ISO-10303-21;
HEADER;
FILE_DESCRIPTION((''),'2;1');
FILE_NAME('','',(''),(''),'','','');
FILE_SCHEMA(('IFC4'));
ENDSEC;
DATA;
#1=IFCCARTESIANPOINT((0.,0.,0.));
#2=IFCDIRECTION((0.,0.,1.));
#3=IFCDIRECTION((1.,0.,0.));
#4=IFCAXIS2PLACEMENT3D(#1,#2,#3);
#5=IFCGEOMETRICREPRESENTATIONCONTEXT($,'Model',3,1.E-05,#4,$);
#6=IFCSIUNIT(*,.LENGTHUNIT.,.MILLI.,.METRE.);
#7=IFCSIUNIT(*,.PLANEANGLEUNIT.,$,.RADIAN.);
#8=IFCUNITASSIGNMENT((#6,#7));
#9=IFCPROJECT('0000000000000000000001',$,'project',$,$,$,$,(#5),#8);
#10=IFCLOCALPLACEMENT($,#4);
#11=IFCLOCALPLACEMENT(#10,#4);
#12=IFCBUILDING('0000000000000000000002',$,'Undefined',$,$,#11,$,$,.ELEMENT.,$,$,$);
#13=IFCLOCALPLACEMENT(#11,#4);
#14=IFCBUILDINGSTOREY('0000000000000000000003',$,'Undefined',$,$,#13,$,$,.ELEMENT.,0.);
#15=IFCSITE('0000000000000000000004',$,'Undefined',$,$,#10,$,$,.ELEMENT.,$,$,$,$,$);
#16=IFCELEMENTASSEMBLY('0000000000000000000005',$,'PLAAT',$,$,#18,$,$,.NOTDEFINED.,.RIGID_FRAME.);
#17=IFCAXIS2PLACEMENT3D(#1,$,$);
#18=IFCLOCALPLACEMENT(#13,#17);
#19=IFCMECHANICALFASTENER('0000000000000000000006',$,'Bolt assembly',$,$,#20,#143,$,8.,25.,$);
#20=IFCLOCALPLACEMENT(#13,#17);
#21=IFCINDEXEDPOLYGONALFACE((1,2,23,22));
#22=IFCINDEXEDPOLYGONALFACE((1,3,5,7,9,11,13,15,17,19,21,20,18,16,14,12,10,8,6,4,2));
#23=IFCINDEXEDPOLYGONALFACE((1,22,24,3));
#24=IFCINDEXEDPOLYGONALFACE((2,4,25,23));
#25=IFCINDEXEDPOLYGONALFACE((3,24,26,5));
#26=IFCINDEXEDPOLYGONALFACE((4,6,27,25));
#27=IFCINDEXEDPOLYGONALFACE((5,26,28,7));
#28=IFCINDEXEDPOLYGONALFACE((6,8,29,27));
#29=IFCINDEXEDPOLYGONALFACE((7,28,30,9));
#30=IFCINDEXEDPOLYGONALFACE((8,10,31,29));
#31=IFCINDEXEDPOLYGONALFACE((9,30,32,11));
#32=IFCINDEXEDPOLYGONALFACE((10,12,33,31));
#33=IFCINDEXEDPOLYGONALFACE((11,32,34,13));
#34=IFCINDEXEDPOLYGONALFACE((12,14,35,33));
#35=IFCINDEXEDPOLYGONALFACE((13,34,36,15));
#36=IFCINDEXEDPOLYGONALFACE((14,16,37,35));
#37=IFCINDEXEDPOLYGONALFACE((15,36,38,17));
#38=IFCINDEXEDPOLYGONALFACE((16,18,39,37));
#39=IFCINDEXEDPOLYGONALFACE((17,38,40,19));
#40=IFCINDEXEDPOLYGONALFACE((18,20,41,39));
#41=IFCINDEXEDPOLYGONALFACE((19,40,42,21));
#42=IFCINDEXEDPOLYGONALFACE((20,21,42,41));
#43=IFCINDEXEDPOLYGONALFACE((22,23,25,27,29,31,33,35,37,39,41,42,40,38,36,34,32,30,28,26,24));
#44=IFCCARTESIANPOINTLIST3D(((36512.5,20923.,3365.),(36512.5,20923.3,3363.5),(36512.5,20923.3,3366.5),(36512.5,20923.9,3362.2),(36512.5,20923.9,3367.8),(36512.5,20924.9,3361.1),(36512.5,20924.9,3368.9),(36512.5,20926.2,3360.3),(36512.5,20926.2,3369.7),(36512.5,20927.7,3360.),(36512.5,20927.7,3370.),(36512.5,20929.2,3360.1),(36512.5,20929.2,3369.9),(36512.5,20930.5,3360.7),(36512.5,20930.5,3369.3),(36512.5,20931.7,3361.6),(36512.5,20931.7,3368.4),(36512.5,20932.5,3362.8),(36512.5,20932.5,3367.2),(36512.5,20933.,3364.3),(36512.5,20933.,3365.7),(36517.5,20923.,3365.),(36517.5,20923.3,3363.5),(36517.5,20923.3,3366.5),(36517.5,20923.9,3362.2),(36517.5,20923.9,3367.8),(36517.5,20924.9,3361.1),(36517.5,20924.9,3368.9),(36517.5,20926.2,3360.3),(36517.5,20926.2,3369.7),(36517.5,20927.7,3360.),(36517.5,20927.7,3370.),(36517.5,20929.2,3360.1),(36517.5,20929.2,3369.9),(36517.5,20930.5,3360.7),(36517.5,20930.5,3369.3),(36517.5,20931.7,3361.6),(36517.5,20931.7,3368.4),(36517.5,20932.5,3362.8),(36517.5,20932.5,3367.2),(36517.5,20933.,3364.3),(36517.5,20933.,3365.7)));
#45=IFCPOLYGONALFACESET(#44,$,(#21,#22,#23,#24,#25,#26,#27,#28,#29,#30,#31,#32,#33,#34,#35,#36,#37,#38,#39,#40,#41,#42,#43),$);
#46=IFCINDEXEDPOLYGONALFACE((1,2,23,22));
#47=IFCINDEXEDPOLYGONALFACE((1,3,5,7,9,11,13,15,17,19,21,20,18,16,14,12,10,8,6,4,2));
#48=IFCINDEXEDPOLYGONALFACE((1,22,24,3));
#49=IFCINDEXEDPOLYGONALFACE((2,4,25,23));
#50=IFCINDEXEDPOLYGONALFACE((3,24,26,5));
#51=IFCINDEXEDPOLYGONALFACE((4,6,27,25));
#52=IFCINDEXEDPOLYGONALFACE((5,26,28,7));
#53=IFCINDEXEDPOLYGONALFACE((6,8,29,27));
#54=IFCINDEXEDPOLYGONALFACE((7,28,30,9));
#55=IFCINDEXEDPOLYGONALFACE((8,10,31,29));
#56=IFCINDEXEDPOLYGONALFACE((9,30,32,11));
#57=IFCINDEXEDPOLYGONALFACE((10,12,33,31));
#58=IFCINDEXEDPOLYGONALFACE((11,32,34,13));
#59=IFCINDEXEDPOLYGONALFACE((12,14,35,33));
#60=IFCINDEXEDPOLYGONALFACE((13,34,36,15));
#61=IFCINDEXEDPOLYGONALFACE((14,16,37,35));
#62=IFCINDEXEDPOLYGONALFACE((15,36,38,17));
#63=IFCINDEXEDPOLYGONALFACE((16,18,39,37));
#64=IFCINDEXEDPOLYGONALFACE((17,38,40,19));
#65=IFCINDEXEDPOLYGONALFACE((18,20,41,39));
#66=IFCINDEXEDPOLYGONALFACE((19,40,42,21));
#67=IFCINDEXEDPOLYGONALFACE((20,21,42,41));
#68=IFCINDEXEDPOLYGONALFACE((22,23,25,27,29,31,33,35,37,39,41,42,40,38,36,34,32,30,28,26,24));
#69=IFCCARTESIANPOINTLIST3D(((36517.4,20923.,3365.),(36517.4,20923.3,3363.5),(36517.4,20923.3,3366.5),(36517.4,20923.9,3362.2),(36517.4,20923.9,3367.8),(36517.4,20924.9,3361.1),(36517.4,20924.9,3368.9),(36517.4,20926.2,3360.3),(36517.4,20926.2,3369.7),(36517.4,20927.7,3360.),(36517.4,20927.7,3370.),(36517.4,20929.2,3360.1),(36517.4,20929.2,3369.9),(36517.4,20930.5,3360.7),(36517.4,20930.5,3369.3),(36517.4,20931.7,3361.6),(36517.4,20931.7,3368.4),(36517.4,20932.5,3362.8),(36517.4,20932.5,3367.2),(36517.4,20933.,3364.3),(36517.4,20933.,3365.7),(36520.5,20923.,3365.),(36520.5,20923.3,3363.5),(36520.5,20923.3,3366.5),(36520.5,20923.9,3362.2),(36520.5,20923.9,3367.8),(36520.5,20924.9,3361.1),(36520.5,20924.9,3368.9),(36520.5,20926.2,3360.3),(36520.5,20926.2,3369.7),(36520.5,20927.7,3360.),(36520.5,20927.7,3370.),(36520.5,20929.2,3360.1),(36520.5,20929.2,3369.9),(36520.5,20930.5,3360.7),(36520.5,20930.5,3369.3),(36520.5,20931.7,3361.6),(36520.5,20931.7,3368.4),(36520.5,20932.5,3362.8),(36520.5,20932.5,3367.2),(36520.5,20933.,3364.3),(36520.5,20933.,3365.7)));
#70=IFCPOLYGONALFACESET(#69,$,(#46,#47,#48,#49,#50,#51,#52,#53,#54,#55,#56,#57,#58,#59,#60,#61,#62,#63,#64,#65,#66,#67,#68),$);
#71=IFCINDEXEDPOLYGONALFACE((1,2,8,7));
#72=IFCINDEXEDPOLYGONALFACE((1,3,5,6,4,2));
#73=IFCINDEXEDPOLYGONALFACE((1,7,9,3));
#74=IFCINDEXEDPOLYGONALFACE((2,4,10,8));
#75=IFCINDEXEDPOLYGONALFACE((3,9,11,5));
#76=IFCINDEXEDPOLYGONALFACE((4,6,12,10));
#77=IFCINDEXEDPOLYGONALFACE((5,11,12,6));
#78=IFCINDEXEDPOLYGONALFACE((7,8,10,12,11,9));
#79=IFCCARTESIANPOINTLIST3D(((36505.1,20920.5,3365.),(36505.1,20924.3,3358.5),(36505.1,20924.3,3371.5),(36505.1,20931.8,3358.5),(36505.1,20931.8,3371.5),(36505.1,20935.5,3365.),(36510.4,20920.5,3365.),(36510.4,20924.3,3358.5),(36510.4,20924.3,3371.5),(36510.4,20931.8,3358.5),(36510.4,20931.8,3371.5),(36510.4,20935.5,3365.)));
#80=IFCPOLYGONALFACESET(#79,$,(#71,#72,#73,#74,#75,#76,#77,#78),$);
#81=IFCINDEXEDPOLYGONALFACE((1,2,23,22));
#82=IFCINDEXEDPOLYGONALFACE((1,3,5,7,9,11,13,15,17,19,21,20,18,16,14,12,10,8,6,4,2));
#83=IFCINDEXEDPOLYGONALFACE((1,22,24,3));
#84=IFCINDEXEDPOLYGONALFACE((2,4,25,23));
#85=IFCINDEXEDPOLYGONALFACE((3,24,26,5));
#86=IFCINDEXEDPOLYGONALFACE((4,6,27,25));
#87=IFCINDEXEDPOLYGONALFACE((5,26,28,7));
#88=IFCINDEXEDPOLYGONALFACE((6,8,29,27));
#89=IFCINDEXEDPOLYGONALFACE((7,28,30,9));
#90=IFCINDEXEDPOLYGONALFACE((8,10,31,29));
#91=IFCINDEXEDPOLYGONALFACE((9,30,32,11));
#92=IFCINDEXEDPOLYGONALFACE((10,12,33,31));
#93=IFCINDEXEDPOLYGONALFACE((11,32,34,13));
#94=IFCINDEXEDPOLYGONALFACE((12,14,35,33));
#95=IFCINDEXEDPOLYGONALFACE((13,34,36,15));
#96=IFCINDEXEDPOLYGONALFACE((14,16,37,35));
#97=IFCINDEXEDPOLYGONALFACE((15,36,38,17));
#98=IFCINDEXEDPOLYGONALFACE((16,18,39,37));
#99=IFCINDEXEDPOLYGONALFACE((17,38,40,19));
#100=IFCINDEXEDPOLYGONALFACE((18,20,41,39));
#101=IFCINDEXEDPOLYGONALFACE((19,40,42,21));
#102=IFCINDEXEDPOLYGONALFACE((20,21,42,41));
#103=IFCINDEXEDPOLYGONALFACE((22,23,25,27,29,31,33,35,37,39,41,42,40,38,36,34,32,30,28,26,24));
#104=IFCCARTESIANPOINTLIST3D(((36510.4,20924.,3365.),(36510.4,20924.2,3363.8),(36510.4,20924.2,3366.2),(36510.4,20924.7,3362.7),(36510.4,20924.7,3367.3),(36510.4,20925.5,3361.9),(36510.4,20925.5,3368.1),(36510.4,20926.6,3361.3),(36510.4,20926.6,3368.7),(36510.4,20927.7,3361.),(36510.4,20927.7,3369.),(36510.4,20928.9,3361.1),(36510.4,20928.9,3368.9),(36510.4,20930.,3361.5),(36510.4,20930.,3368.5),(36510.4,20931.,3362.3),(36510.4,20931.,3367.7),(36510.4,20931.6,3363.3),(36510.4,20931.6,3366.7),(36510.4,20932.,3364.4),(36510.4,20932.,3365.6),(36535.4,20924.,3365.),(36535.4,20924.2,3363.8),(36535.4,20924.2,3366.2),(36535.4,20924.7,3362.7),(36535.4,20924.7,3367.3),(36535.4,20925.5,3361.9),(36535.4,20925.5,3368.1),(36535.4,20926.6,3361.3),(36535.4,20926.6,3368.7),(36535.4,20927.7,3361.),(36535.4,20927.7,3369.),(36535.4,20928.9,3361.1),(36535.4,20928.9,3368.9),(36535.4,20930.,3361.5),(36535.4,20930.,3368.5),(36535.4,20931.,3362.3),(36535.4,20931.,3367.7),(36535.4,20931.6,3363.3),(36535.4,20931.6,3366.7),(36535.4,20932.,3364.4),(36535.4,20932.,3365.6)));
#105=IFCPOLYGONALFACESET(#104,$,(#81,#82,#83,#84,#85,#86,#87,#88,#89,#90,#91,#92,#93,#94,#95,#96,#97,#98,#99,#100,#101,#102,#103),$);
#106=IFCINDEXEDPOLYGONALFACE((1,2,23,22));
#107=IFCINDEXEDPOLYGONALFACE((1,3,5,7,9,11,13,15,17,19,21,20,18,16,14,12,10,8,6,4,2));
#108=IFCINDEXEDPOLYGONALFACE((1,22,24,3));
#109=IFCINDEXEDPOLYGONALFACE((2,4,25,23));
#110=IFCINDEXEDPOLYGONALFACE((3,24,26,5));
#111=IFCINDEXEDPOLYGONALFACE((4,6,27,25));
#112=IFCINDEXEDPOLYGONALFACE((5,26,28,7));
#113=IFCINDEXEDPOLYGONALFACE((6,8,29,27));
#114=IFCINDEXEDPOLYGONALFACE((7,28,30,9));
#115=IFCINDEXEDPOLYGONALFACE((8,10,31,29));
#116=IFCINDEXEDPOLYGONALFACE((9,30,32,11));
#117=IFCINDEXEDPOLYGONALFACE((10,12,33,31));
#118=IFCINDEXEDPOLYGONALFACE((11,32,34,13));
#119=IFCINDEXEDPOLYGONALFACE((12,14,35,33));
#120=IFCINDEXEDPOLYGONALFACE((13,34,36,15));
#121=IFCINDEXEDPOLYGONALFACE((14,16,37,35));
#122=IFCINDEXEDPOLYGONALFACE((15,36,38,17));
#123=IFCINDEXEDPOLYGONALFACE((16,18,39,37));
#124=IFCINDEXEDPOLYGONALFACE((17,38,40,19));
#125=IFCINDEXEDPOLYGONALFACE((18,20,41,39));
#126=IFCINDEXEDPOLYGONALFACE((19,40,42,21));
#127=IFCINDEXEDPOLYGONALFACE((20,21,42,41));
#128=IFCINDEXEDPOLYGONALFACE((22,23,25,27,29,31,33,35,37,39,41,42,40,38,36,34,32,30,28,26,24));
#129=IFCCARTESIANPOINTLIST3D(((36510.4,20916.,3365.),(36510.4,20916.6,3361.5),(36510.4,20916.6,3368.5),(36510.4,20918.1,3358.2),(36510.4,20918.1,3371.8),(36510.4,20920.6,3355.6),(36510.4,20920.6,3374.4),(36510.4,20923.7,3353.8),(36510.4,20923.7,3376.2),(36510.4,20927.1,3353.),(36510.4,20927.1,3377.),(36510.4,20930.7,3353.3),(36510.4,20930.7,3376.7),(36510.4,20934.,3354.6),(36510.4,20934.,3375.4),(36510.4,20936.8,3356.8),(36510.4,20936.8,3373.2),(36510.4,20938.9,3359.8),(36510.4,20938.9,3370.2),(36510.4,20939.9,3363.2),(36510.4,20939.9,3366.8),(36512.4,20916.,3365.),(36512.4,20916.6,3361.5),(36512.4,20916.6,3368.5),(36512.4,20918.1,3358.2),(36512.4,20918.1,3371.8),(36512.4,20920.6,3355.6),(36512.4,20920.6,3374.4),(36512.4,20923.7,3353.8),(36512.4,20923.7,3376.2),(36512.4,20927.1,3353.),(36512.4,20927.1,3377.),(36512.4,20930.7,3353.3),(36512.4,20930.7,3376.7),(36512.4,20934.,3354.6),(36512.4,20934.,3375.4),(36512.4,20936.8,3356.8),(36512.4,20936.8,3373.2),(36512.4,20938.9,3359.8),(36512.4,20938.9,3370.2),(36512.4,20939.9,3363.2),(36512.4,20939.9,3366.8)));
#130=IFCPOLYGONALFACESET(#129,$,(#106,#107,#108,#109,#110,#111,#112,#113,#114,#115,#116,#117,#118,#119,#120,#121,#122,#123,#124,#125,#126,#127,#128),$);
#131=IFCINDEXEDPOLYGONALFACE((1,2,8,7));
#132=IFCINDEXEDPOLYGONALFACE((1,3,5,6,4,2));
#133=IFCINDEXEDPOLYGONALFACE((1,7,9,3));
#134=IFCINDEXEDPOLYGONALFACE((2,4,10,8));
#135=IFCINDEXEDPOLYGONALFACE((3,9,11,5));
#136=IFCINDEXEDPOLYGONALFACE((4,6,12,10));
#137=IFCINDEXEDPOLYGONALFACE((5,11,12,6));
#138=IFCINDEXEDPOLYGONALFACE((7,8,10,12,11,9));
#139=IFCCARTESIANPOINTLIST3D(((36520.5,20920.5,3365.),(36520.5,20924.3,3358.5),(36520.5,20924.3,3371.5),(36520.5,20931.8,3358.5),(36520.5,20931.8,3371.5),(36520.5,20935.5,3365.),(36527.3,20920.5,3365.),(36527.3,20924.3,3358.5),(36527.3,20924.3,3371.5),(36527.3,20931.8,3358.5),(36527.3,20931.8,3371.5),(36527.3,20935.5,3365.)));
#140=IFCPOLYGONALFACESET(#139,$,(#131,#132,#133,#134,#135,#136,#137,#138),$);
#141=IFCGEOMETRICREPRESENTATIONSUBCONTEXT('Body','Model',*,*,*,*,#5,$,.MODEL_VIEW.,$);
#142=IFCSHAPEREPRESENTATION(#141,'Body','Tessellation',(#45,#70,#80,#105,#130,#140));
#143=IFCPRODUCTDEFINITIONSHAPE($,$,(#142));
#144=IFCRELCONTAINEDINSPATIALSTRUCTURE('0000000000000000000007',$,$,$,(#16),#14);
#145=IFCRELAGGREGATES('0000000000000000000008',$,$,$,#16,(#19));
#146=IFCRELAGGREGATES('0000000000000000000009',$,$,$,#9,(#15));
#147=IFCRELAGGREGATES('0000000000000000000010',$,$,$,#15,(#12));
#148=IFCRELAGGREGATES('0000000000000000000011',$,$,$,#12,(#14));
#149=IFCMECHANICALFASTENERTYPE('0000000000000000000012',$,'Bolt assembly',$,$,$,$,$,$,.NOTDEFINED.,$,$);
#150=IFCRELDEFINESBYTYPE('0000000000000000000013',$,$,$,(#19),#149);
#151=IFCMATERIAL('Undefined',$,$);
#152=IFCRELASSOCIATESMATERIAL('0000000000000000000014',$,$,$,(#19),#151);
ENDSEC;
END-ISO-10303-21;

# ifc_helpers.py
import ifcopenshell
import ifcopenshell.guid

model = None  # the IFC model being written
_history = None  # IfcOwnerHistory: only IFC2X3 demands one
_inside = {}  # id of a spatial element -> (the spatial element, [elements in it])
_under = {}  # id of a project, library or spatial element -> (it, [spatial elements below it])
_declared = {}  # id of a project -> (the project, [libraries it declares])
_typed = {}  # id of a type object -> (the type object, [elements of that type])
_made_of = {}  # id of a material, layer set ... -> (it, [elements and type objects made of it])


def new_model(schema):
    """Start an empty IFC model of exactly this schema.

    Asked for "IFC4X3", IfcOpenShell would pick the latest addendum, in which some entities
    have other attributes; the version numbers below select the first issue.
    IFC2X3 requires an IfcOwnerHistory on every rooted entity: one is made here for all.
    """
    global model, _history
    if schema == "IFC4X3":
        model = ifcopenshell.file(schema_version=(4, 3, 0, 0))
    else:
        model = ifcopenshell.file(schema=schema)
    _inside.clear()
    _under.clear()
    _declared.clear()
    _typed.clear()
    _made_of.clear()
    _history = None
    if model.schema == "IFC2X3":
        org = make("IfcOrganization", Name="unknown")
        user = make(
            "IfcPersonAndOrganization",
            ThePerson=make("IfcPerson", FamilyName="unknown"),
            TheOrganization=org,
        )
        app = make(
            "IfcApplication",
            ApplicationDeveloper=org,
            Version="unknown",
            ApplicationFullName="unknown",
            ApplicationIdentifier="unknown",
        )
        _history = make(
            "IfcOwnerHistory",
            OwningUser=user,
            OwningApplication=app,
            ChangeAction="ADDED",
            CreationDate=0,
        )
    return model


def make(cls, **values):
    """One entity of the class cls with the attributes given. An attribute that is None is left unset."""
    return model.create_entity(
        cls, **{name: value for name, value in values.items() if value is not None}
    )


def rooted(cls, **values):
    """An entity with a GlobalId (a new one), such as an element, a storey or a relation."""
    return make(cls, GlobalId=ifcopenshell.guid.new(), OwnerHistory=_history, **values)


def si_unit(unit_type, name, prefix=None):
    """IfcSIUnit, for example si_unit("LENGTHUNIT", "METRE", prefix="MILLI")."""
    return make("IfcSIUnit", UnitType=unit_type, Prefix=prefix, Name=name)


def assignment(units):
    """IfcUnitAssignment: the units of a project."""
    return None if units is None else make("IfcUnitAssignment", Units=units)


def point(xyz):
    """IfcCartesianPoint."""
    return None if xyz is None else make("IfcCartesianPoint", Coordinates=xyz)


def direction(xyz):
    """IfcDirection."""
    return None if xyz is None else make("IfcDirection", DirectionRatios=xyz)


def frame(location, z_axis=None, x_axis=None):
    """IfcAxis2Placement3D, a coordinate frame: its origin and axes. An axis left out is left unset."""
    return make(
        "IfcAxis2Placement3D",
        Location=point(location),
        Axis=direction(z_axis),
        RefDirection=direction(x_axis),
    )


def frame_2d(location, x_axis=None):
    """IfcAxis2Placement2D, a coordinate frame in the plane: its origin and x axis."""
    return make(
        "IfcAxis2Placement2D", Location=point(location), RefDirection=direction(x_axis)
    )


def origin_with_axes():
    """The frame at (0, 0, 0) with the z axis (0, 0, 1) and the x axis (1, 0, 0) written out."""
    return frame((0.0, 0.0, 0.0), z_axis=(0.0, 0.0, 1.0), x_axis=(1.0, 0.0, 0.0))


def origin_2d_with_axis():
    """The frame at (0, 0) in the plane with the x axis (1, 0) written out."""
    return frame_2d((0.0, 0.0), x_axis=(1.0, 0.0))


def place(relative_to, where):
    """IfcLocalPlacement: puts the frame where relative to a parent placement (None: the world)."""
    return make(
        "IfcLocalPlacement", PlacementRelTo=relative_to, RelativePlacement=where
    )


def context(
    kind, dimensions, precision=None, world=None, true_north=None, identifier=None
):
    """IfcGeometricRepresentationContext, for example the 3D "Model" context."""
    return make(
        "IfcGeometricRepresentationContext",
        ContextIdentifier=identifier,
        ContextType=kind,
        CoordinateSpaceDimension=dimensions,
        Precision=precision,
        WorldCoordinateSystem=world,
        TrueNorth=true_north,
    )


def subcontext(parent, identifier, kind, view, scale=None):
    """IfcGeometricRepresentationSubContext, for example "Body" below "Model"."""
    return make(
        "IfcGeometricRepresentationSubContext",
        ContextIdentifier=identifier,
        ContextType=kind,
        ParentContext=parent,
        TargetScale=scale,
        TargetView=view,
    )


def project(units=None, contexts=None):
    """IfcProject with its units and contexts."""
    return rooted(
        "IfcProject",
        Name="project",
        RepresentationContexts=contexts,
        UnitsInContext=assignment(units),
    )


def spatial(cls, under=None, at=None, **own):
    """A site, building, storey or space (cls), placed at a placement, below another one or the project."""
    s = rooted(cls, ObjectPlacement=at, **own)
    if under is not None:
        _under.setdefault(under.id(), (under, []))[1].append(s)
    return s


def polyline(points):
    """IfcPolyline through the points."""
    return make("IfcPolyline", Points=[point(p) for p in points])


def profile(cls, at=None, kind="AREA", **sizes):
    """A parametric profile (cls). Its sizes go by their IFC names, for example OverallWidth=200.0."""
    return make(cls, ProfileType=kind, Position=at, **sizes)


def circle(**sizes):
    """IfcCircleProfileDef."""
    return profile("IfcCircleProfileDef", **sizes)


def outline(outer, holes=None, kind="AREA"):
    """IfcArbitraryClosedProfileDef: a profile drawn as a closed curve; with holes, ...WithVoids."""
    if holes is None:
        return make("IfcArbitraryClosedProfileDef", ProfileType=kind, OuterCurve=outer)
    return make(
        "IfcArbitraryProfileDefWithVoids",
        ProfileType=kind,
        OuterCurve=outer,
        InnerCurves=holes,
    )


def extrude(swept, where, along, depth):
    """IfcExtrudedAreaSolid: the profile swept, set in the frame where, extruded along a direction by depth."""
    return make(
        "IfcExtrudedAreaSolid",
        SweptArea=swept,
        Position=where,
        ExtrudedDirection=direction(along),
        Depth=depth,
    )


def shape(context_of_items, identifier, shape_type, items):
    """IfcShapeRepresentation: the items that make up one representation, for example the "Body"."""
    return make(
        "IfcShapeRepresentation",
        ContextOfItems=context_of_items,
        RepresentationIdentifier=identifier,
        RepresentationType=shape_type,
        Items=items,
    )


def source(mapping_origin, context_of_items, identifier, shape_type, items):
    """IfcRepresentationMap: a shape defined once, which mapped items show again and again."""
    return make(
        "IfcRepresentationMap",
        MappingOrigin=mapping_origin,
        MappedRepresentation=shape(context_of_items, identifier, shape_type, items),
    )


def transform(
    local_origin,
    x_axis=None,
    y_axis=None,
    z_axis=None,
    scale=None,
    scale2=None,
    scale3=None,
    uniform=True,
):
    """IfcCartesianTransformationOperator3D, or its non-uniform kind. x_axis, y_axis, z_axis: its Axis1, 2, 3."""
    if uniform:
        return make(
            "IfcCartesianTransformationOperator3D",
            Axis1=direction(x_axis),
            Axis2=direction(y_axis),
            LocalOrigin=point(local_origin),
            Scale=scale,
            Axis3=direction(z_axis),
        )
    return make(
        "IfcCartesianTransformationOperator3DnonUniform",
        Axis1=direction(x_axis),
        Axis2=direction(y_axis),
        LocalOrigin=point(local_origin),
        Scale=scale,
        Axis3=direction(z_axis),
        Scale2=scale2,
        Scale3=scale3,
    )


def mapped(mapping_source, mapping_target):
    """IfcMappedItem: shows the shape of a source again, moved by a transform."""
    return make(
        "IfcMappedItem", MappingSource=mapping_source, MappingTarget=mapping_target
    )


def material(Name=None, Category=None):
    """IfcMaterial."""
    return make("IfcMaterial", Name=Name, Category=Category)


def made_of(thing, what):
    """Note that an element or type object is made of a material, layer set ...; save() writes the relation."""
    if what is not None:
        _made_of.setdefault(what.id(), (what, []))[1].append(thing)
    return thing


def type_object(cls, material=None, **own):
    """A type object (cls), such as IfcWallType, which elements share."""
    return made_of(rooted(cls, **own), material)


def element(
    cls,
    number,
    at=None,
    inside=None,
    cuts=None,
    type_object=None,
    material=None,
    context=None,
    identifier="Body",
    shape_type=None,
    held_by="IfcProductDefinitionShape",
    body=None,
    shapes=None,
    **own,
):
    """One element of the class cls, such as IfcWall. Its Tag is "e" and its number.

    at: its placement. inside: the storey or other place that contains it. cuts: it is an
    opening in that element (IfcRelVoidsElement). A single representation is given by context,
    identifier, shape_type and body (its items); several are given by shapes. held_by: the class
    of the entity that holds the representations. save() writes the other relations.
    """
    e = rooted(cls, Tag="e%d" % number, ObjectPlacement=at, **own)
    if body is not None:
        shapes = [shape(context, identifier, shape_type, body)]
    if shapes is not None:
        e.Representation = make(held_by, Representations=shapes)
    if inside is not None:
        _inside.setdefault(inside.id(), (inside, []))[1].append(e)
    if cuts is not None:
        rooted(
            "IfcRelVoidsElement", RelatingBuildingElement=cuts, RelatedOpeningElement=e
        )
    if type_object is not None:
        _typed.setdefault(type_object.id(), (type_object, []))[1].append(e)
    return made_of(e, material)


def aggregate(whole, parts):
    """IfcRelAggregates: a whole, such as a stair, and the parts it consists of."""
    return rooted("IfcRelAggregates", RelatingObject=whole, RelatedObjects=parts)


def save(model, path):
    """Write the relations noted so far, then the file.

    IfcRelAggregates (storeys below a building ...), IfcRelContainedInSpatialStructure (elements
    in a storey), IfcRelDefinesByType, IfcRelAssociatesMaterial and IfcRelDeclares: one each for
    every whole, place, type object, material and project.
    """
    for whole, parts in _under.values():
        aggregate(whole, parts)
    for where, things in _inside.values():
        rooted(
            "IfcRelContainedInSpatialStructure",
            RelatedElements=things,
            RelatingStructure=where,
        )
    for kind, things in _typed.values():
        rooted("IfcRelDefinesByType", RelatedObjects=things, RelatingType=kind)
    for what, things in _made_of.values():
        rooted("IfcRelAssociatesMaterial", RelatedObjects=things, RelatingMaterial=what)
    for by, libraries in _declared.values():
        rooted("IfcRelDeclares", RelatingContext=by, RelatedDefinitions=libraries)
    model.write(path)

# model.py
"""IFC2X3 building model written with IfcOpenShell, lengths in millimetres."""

from ifc_helpers import new_model, si_unit, frame, origin_with_axes, origin_2d_with_axis, place, context, subcontext, project, spatial, polyline, circle, outline, extrude, source, transform, mapped, material, type_object, element, aggregate, save


model = new_model("IFC2X3")

# Units and contexts
model_context = context("Model", 3, precision=1e-05, world=origin_with_axes())
body_context = subcontext(model_context, "Body", "Model", "MODEL_VIEW")
ifc_project = project(units=[si_unit("LENGTHUNIT", "METRE", prefix="MILLI"), si_unit("PLANEANGLEUNIT", "RADIAN")], contexts=[model_context])

# Site, building, storey
site_placement = place(None, origin_with_axes())
site = spatial("IfcSite", under=ifc_project, at=site_placement, Name="Undefined", CompositionType="ELEMENT")
building_placement = place(site_placement, origin_with_axes())
building = spatial("IfcBuilding", under=site, at=building_placement, Name="Undefined", CompositionType="ELEMENT")
storey_placement = place(building_placement, origin_with_axes())
storey = spatial("IfcBuildingStorey", under=building, at=storey_placement, Name="Undefined", CompositionType="ELEMENT", Elevation=0.0)

# Shared definitions
ifc_material_1 = material(Name="Undefined")
mechanical_fastener_type = type_object("IfcMechanicalFastenerType", Name="Bolt assembly")
shared_shape_1 = source(origin_with_axes(), body_context, "Body", "SweptSolid", [
    extrude(circle(Radius=5.0, at=origin_2d_with_axis()), frame((0.0, 7.5, 0.0), z_axis=(0.0, 1.0, 0.0), x_axis=(1.0, 0.0, 0.0)), (0.0, 0.0, 1.0), 5.0),
    extrude(circle(Radius=5.0, at=origin_2d_with_axis()), frame((0.0, 12.4, 0.0), z_axis=(0.0, 1.0, 0.0), x_axis=(1.0, 0.0, 0.0)), (0.0, 0.0, 1.0), 3.1),
    extrude(outline(polyline([(7.5, 0.0), (3.8, 6.5), (-3.8, 6.5), (-7.5, 0.0), (-3.8, -6.5), (3.8, -6.5), (7.5, 0.0)])), frame((0.0, 0.1, 0.0), z_axis=(0.0, 1.0, 0.0), x_axis=(1.0, 0.0, 0.0)), (0.0, 0.0, 1.0), 5.3),
    extrude(circle(Radius=4.0, at=origin_2d_with_axis()), frame((0.0, 5.4, 0.0), z_axis=(0.0, 1.0, 0.0), x_axis=(1.0, 0.0, 0.0)), (0.0, 0.0, 1.0), 25.0),
    extrude(circle(Radius=12.0, at=origin_2d_with_axis()), frame((0.0, 5.4, 0.0), z_axis=(0.0, 1.0, 0.0), x_axis=(1.0, 0.0, 0.0)), (0.0, 0.0, 1.0), 2.0),
    extrude(outline(polyline([(7.5, 0.0), (3.8, 6.5), (-3.8, 6.5), (-7.5, 0.0), (-3.8, -6.5), (3.8, -6.5), (7.5, 0.0)])), frame((0.0, 15.5, 0.0), z_axis=(0.0, 1.0, 0.0), x_axis=(1.0, 0.0, 0.0)), (0.0, 0.0, 1.0), 6.8),
])

# Element assembly, mechanical fastener
assembly_1_placement = place(storey_placement, origin_with_axes())
assembly_1 = element("IfcElementAssembly", 1, at=assembly_1_placement, inside=storey, Name="PLAAT", AssemblyPlace="NOTDEFINED", PredefinedType="RIGID_FRAME")
mechanical_fastener_1_placement = place(assembly_1_placement, frame((36505.0, 20928.0, 3365.0), z_axis=(0.0, 0.000002, 1.0), x_axis=(0.0, -1.0, 0.000002)))
mechanical_fastener_1 = element("IfcMechanicalFastener", 2, at=mechanical_fastener_1_placement, type_object=mechanical_fastener_type, material=ifc_material_1, Name="Bolt assembly", NominalDiameter=8.0, NominalLength=25.0, context=body_context, shape_type="MappedRepresentation", body=[
    mapped(shared_shape_1, transform((0.0, 0.0, 0.0))),
])
aggregate(assembly_1, [mechanical_fastener_1])

save(model, "model.ifc")
